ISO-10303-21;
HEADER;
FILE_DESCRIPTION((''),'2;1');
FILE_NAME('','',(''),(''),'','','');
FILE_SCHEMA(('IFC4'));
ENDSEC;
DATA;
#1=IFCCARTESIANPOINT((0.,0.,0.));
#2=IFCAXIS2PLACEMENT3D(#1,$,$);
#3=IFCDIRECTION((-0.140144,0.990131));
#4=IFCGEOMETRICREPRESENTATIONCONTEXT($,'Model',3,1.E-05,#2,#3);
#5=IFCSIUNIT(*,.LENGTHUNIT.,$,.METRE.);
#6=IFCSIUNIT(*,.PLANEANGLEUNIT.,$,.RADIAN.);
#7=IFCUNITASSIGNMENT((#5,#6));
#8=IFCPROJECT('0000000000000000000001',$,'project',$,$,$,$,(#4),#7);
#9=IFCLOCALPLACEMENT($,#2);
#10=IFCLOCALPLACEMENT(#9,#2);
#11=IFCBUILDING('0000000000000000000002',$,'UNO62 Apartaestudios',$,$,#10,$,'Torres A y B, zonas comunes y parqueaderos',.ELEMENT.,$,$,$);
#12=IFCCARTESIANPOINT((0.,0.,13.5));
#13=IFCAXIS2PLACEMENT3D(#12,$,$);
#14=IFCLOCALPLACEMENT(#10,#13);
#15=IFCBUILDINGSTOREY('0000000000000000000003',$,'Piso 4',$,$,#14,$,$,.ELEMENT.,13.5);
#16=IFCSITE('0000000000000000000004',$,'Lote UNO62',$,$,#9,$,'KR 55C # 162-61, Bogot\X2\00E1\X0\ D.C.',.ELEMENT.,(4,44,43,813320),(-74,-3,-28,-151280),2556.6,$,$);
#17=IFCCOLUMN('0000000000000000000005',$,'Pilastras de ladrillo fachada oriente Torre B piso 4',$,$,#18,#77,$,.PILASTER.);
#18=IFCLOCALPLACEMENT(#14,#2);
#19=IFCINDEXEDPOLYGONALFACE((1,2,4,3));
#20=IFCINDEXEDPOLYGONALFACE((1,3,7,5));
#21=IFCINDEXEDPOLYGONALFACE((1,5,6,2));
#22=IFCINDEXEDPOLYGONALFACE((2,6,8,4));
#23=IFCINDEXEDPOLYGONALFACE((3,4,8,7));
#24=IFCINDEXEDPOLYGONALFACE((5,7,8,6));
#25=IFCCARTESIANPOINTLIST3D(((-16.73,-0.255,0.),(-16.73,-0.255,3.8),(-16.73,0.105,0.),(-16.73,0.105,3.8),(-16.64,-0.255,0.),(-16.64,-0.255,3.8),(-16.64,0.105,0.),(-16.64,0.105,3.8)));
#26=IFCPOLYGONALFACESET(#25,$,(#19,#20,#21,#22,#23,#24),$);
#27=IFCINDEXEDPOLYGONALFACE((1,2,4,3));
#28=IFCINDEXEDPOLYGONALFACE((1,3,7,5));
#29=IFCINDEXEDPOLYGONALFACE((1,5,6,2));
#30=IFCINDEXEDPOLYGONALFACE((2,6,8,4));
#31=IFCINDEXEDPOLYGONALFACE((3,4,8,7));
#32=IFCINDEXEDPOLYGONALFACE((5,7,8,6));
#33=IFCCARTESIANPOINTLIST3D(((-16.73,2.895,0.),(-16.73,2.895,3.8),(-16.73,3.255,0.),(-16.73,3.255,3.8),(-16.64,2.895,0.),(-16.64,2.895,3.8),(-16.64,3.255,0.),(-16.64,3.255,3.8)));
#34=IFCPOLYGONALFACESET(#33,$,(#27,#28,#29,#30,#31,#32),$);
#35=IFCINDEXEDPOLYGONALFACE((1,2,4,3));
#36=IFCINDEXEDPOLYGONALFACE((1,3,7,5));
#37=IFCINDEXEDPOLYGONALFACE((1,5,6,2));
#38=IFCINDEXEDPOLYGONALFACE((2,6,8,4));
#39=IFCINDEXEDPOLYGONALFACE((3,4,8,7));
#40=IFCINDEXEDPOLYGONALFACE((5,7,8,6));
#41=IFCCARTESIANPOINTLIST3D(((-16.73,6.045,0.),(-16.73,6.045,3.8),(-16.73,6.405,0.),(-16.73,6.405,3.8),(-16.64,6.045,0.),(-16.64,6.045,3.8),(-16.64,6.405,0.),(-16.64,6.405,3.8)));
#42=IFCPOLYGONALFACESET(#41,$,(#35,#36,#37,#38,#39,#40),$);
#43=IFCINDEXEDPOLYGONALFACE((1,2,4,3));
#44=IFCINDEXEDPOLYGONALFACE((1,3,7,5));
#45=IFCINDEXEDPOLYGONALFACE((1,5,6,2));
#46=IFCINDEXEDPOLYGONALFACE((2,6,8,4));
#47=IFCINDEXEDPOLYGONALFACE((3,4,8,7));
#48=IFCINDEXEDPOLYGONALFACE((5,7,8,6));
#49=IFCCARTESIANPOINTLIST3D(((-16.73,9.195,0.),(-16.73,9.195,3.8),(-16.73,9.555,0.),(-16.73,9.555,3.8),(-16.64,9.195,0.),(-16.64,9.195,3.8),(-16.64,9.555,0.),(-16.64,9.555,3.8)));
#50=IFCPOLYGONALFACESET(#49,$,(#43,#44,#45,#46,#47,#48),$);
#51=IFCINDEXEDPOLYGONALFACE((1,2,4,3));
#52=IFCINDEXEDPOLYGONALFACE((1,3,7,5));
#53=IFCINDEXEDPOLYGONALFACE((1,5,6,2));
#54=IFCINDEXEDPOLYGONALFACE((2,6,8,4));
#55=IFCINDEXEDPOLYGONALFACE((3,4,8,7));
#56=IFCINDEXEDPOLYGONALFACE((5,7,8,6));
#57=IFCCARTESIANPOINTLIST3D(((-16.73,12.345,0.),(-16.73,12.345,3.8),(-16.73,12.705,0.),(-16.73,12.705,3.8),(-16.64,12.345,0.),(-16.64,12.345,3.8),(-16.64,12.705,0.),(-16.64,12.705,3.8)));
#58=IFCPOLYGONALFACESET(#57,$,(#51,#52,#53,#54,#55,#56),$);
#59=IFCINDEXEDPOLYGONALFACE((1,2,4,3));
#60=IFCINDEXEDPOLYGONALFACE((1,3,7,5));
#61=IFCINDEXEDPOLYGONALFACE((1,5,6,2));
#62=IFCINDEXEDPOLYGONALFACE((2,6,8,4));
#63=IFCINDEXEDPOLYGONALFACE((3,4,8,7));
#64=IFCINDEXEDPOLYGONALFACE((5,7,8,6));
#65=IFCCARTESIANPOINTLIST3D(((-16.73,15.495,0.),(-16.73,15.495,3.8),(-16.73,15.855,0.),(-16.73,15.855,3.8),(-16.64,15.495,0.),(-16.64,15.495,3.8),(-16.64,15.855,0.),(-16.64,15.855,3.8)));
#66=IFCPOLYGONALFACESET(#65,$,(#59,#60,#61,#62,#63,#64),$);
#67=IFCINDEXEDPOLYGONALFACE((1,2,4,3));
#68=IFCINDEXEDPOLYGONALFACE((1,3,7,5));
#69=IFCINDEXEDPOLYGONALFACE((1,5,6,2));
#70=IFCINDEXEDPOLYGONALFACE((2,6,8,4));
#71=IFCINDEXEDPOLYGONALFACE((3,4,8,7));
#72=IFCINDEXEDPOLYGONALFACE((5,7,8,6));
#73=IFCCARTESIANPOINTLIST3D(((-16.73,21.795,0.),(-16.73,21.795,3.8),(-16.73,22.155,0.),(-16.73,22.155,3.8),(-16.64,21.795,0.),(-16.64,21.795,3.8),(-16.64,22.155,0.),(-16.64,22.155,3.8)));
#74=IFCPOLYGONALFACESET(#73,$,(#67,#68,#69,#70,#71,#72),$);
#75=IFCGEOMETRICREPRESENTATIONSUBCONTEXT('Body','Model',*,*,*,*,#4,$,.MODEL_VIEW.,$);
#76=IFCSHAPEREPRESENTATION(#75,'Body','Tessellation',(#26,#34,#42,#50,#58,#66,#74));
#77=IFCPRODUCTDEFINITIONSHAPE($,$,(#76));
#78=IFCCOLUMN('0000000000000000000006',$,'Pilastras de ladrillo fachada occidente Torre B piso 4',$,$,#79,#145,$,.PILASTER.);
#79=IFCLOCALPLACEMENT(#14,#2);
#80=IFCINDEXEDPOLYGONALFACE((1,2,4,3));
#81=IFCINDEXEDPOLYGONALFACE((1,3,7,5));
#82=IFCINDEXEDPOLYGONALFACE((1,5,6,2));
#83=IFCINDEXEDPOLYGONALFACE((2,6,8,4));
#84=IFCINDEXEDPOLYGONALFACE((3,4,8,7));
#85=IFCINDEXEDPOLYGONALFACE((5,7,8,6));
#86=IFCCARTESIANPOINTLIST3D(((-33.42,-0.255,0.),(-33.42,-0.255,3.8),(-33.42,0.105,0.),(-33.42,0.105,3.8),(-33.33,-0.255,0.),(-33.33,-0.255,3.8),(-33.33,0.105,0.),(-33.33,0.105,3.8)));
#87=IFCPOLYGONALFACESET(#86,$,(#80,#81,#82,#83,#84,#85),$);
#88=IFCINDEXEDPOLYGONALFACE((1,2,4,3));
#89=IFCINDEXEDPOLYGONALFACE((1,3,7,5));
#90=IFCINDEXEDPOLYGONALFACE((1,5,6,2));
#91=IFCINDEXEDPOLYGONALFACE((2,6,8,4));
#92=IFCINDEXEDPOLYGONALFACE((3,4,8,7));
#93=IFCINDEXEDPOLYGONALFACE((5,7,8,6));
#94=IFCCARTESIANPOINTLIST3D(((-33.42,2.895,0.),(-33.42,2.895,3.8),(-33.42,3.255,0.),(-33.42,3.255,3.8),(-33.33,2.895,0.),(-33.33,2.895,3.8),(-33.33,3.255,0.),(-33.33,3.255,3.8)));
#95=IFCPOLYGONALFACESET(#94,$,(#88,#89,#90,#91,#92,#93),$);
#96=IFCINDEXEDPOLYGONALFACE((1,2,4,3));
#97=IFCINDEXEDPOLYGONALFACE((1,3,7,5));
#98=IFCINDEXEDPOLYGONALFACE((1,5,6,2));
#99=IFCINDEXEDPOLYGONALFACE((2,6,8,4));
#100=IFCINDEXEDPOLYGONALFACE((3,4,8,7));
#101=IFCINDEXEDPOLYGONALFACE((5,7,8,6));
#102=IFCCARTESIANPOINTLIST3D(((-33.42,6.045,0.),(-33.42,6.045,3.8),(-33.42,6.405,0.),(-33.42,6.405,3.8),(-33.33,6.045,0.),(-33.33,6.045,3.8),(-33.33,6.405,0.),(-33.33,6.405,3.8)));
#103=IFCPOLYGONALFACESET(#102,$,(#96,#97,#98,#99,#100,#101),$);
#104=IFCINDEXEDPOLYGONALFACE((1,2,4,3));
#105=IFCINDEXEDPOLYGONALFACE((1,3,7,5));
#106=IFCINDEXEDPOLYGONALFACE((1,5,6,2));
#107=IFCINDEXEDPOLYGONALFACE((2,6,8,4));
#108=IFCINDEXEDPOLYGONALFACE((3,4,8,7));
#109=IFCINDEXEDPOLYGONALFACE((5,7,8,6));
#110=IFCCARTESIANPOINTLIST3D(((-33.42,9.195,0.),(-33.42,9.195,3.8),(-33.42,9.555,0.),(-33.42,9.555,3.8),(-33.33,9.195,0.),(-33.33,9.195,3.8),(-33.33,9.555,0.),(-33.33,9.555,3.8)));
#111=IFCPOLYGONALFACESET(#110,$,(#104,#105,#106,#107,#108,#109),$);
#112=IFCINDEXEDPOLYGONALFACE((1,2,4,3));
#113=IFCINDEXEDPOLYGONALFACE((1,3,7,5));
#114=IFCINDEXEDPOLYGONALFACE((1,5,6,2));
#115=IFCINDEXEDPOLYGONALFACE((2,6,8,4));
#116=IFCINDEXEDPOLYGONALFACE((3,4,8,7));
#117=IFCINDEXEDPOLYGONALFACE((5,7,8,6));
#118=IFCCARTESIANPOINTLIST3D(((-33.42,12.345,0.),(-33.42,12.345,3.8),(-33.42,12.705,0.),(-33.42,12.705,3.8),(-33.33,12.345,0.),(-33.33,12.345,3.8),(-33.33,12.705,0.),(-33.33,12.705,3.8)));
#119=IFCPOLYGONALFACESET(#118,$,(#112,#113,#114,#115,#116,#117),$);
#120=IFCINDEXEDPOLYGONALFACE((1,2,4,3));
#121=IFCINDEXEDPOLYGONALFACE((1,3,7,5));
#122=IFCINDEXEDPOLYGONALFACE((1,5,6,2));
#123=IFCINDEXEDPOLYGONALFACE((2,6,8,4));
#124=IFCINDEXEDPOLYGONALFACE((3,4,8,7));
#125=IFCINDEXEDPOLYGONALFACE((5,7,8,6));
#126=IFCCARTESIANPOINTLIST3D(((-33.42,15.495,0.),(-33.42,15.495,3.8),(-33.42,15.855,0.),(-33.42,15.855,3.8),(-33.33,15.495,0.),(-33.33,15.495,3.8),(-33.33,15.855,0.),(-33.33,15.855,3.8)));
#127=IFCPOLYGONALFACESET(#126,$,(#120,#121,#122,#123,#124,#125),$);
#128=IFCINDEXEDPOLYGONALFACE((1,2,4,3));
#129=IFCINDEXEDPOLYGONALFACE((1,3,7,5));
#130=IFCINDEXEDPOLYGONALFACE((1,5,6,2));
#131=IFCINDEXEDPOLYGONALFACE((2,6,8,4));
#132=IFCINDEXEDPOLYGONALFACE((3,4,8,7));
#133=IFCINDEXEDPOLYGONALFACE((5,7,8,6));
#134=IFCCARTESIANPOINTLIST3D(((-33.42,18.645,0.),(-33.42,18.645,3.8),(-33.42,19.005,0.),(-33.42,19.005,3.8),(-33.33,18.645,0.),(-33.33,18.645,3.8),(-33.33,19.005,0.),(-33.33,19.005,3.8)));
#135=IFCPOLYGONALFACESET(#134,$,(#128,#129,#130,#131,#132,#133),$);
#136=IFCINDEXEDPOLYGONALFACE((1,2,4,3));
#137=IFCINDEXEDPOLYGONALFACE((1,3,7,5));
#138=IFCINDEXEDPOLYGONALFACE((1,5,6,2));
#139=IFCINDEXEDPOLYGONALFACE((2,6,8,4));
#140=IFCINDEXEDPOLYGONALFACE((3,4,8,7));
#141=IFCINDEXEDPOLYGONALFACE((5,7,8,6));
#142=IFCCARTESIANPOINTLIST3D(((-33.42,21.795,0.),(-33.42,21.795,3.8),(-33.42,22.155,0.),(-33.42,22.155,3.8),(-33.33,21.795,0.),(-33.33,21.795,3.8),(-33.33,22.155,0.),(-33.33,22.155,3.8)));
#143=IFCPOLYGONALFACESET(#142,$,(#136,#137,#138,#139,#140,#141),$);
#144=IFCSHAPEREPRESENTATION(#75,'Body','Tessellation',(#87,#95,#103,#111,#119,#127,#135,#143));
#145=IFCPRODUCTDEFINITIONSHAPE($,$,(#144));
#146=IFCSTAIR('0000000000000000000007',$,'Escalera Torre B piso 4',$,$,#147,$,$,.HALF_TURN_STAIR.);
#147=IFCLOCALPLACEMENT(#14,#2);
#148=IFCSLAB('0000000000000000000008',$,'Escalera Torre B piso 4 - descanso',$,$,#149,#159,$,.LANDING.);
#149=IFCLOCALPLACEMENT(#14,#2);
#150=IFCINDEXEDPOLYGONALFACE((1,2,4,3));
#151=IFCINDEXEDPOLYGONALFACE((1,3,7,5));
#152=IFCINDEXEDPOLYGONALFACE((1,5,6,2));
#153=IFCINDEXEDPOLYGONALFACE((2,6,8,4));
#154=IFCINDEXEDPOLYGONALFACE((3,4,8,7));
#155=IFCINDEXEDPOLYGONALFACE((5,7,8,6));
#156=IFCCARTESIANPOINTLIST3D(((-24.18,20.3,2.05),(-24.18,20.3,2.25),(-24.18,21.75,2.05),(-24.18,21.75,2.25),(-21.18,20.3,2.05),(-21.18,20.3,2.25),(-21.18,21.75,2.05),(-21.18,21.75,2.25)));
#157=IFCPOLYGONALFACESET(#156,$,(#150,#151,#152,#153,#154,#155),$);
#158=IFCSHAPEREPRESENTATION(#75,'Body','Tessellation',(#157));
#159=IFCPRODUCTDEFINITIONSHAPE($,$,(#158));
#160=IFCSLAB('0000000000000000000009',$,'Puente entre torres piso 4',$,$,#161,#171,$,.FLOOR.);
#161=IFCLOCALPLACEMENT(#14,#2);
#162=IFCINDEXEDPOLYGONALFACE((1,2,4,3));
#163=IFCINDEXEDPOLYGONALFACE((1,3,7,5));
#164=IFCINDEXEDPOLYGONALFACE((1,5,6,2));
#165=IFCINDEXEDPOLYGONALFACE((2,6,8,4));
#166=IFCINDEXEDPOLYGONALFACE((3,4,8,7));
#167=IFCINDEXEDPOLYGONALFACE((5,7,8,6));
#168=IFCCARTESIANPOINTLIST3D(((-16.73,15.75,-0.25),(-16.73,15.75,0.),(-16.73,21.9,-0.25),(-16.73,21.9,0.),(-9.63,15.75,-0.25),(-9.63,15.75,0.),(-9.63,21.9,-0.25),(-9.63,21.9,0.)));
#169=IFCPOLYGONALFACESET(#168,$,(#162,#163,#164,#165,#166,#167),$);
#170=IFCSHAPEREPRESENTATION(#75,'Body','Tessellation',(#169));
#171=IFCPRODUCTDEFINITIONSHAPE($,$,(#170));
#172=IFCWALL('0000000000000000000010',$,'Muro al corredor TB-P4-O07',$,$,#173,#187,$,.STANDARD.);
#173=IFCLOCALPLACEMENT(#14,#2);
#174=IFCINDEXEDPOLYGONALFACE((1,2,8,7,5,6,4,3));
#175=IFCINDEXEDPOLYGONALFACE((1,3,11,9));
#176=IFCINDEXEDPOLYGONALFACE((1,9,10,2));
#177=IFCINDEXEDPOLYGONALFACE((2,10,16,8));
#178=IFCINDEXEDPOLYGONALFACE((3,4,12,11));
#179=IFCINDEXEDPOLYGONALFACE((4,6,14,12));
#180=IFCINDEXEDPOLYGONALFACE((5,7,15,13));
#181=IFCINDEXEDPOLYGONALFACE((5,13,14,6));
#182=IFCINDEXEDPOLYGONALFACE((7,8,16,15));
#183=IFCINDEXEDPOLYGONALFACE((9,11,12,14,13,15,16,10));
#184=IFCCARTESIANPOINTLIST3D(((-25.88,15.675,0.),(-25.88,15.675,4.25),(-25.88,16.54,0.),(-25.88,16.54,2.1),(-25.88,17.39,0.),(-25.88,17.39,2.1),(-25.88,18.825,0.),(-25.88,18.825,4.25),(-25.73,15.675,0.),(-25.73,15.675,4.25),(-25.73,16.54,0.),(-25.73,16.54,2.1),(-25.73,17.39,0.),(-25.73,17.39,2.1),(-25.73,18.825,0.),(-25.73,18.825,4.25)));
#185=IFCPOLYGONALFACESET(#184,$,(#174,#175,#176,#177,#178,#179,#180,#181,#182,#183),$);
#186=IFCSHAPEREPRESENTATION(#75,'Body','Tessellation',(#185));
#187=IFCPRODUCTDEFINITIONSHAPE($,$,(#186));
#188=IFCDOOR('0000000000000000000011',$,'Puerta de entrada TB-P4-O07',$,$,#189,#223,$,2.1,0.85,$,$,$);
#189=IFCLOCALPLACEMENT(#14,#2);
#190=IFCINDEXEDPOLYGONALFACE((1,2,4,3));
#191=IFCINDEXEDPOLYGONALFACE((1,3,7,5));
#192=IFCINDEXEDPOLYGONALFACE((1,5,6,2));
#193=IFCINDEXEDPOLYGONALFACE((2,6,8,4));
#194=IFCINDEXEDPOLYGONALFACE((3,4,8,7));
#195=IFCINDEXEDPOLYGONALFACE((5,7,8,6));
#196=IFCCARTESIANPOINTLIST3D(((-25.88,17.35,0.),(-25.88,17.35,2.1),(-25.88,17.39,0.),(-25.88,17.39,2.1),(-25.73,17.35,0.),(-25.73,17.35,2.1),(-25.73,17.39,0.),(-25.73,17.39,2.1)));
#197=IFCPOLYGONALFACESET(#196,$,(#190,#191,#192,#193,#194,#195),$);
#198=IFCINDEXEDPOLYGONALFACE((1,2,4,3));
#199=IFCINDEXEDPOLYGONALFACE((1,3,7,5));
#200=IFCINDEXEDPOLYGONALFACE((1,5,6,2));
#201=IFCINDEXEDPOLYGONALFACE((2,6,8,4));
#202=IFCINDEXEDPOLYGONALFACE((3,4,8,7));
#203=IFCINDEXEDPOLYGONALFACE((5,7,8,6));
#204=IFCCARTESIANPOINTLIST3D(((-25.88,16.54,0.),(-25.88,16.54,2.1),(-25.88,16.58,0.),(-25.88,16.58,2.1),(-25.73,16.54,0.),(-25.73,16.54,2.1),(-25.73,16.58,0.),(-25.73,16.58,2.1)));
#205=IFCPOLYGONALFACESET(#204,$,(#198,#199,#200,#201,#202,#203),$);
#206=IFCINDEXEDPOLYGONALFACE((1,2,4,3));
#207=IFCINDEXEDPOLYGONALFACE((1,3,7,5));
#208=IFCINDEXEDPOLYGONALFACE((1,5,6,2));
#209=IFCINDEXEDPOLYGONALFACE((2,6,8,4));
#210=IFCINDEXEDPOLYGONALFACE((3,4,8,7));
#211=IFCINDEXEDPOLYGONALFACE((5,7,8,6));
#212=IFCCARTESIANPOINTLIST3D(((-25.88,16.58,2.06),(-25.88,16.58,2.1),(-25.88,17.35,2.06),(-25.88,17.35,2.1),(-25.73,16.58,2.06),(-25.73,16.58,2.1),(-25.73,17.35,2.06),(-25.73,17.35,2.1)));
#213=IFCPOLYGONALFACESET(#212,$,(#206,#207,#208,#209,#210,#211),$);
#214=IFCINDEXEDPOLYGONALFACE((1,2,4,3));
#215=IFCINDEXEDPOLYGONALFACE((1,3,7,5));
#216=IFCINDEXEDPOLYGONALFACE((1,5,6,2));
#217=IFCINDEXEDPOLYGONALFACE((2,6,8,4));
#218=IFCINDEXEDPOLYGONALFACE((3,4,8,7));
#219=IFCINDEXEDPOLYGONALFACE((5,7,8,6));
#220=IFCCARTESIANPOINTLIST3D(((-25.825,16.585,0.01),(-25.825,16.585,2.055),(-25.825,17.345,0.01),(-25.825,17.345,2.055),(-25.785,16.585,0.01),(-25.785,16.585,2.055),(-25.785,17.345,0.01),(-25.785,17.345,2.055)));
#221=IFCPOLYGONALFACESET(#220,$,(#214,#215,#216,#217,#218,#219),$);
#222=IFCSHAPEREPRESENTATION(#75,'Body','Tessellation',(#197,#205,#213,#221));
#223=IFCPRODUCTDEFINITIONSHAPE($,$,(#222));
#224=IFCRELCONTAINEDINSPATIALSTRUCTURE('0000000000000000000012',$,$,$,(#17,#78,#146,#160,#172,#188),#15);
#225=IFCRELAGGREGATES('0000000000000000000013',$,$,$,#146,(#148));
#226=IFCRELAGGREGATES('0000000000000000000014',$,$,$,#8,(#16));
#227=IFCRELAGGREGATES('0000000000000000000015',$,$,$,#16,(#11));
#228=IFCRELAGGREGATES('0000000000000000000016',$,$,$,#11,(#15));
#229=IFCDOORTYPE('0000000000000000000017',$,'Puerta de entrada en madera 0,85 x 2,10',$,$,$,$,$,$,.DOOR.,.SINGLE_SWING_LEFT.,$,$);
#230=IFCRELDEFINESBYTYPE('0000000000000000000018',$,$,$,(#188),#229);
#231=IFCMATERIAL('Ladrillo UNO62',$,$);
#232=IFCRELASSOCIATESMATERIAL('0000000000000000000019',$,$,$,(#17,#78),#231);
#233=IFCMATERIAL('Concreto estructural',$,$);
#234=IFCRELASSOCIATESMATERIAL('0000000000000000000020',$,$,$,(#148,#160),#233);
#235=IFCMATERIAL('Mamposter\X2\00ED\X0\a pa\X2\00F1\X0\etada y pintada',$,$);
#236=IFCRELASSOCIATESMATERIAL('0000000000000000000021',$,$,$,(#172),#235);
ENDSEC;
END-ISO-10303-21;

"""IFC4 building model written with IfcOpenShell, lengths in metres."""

from ifc_helpers import new_model, si_unit, direction, frame, frame_2d, origin, place, context, subcontext, project, spatial, rectangle, extrude, source, transform, mapped, material, type_object, type_shapes, element, fill, aggregate, save


model = new_model("IFC4")

# Units and contexts
model_context = context("Model", 3, precision=1e-05, world=origin(), true_north=direction((-0.140144, 0.990131)))
body_context = subcontext(model_context, "Body", "Model", "MODEL_VIEW")
ifc_project = project(units=[si_unit("LENGTHUNIT", "METRE"), si_unit("PLANEANGLEUNIT", "RADIAN")], contexts=[model_context])

# Site, building, storey
site_placement = place(None, origin())
site = spatial("IfcSite", under=ifc_project, at=site_placement, Name="Lote UNO62", LongName="KR 55C # 162-61, Bogotá D.C.", CompositionType="ELEMENT", RefLatitude=(4, 44, 43, 813320), RefLongitude=(-74, -3, -28, -151280), RefElevation=2556.6)
building_placement = place(site_placement, origin())
building = spatial("IfcBuilding", under=site, at=building_placement, Name="UNO62 Apartaestudios", LongName="Torres A y B, zonas comunes y parqueaderos", CompositionType="ELEMENT")
storey_placement = place(building_placement, frame((0.0, 0.0, 13.5)))
storey = spatial("IfcBuildingStorey", under=building, at=storey_placement, Name="Piso 4", CompositionType="ELEMENT", Elevation=13.5)

# Columns
ifc_material_1 = material(Name="Ladrillo UNO62")
column_1_placement = place(storey_placement, origin())
element("IfcColumn", 1, at=column_1_placement, inside=storey, material=ifc_material_1, Name="Pilastras de ladrillo fachada oriente Torre B piso 4", PredefinedType="PILASTER", context=body_context, shape_type="SweptSolid", body=[
    extrude(rectangle(XDim=0.09, YDim=0.36, at=frame_2d((-16.685, -0.075))), origin(), (0.0, 0.0, 1.0), 3.8),
    extrude(rectangle(XDim=0.09, YDim=0.36, at=frame_2d((-16.685, 3.075))), origin(), (0.0, 0.0, 1.0), 3.8),
    extrude(rectangle(XDim=0.09, YDim=0.36, at=frame_2d((-16.685, 6.225))), origin(), (0.0, 0.0, 1.0), 3.8),
    extrude(rectangle(XDim=0.09, YDim=0.36, at=frame_2d((-16.685, 9.375))), origin(), (0.0, 0.0, 1.0), 3.8),
    extrude(rectangle(XDim=0.09, YDim=0.36, at=frame_2d((-16.685, 12.525))), origin(), (0.0, 0.0, 1.0), 3.8),
    extrude(rectangle(XDim=0.09, YDim=0.36, at=frame_2d((-16.685, 15.675))), origin(), (0.0, 0.0, 1.0), 3.8),
    extrude(rectangle(XDim=0.09, YDim=0.36, at=frame_2d((-16.685, 21.975))), origin(), (0.0, 0.0, 1.0), 3.8),
])
column_2_placement = place(storey_placement, origin())
element("IfcColumn", 2, at=column_2_placement, inside=storey, material=ifc_material_1, Name="Pilastras de ladrillo fachada occidente Torre B piso 4", PredefinedType="PILASTER", context=body_context, shape_type="SweptSolid", body=[
    extrude(rectangle(XDim=0.09, YDim=0.36, at=frame_2d((-33.375, -0.075))), origin(), (0.0, 0.0, 1.0), 3.8),
    extrude(rectangle(XDim=0.09, YDim=0.36, at=frame_2d((-33.375, 3.075))), origin(), (0.0, 0.0, 1.0), 3.8),
    extrude(rectangle(XDim=0.09, YDim=0.36, at=frame_2d((-33.375, 6.225))), origin(), (0.0, 0.0, 1.0), 3.8),
    extrude(rectangle(XDim=0.09, YDim=0.36, at=frame_2d((-33.375, 9.375))), origin(), (0.0, 0.0, 1.0), 3.8),
    extrude(rectangle(XDim=0.09, YDim=0.36, at=frame_2d((-33.375, 12.525))), origin(), (0.0, 0.0, 1.0), 3.8),
    extrude(rectangle(XDim=0.09, YDim=0.36, at=frame_2d((-33.375, 15.675))), origin(), (0.0, 0.0, 1.0), 3.8),
    extrude(rectangle(XDim=0.09, YDim=0.36, at=frame_2d((-33.375, 18.825))), origin(), (0.0, 0.0, 1.0), 3.8),
    extrude(rectangle(XDim=0.09, YDim=0.36, at=frame_2d((-33.375, 21.975))), origin(), (0.0, 0.0, 1.0), 3.8),
])

# Stair, slab
stair_placement = place(storey_placement, origin())
stair = element("IfcStair", 3, at=stair_placement, inside=storey, Name="Escalera Torre B piso 4", PredefinedType="HALF_TURN_STAIR")
ifc_material_2 = material(Name="Concreto estructural")
slab_1_placement = place(storey_placement, origin())
slab_1 = element("IfcSlab", 4, at=slab_1_placement, material=ifc_material_2, Name="Escalera Torre B piso 4 - descanso", PredefinedType="LANDING", context=body_context, shape_type="SweptSolid", body=[
    extrude(rectangle(XDim=3.0, YDim=1.45, at=frame_2d((-22.68, 21.025))), frame((0.0, 0.0, 2.05)), (0.0, 0.0, 1.0), 0.2),
])

# Slab
slab_2_placement = place(storey_placement, origin())
element("IfcSlab", 5, at=slab_2_placement, inside=storey, material=ifc_material_2, Name="Puente entre torres piso 4", PredefinedType="FLOOR", context=body_context, shape_type="SweptSolid", body=[
    extrude(rectangle(XDim=7.1, YDim=6.15, at=frame_2d((-13.18, 18.825))), frame((0.0, 0.0, -0.25)), (0.0, 0.0, 1.0), 0.25),
])

# Wall, opening, door
ifc_material_3 = material(Name="Mampostería pañetada y pintada")
wall_1_placement = place(storey_placement, origin())
wall_1 = element("IfcWall", 6, at=wall_1_placement, inside=storey, material=ifc_material_3, Name="Muro al corredor TB-P4-O07", PredefinedType="STANDARD", context=body_context, shape_type="SweptSolid", body=[
    extrude(rectangle(XDim=0.15, YDim=3.15, at=frame_2d((-25.805, 17.25))), origin(), (0.0, 0.0, 1.0), 4.25),
])
opening_1_placement = place(wall_1_placement, origin())
opening_1 = element("IfcOpeningElement", 7, at=opening_1_placement, cuts=wall_1, PredefinedType="OPENING", context=body_context, shape_type="SweptSolid", body=[
    extrude(rectangle(XDim=0.25, YDim=0.85, at=frame_2d((-25.805, 16.965))), origin(), (0.0, 0.0, 1.0), 2.1),
])
door_type_1 = type_object("IfcDoorType", Name="Puerta de entrada en madera 0,85 x 2,10", OperationType="SINGLE_SWING_LEFT", PredefinedType="DOOR")
shared_shape_1 = source(origin(), body_context, "Body", "SweptSolid", [
    extrude(rectangle(XDim=0.15, YDim=0.04, at=frame_2d((-0.075, 1.38))), origin(), (0.0, 0.0, 1.0), 2.1),
    extrude(rectangle(XDim=0.15, YDim=0.04, at=frame_2d((-0.075, 2.19))), origin(), (0.0, 0.0, 1.0), 2.1),
    extrude(rectangle(XDim=0.15, YDim=0.77, at=frame_2d((-0.075, 1.785))), frame((0.0, 0.0, 2.06)), (0.0, 0.0, 1.0), 0.04),
    extrude(rectangle(XDim=0.04, YDim=0.76, at=frame_2d((-0.075, 1.785))), frame((0.0, 0.0, 0.01)), (0.0, 0.0, 1.0), 2.045),
])
type_shapes(door_type_1, [shared_shape_1])
placement_1 = place(storey_placement, frame((-25.88, 18.75, 0.0), z_axis=(0.0, 0.0, 1.0), x_axis=(-1.0, 0.0, 0.0)))
door_1_placement = place(placement_1, origin())
door_1 = element("IfcDoor", 8, at=door_1_placement, inside=storey, type_object=door_type_1, Name="Puerta de entrada TB-P4-O07", OverallHeight=2.1, OverallWidth=0.85, context=body_context, shape_type="MappedRepresentation", body=[
    mapped(shared_shape_1, transform((0.0, 0.0, 0.0))),
])
fill(opening_1, door_1)

aggregate(stair, [slab_1])

save(model, "model.ifc")
